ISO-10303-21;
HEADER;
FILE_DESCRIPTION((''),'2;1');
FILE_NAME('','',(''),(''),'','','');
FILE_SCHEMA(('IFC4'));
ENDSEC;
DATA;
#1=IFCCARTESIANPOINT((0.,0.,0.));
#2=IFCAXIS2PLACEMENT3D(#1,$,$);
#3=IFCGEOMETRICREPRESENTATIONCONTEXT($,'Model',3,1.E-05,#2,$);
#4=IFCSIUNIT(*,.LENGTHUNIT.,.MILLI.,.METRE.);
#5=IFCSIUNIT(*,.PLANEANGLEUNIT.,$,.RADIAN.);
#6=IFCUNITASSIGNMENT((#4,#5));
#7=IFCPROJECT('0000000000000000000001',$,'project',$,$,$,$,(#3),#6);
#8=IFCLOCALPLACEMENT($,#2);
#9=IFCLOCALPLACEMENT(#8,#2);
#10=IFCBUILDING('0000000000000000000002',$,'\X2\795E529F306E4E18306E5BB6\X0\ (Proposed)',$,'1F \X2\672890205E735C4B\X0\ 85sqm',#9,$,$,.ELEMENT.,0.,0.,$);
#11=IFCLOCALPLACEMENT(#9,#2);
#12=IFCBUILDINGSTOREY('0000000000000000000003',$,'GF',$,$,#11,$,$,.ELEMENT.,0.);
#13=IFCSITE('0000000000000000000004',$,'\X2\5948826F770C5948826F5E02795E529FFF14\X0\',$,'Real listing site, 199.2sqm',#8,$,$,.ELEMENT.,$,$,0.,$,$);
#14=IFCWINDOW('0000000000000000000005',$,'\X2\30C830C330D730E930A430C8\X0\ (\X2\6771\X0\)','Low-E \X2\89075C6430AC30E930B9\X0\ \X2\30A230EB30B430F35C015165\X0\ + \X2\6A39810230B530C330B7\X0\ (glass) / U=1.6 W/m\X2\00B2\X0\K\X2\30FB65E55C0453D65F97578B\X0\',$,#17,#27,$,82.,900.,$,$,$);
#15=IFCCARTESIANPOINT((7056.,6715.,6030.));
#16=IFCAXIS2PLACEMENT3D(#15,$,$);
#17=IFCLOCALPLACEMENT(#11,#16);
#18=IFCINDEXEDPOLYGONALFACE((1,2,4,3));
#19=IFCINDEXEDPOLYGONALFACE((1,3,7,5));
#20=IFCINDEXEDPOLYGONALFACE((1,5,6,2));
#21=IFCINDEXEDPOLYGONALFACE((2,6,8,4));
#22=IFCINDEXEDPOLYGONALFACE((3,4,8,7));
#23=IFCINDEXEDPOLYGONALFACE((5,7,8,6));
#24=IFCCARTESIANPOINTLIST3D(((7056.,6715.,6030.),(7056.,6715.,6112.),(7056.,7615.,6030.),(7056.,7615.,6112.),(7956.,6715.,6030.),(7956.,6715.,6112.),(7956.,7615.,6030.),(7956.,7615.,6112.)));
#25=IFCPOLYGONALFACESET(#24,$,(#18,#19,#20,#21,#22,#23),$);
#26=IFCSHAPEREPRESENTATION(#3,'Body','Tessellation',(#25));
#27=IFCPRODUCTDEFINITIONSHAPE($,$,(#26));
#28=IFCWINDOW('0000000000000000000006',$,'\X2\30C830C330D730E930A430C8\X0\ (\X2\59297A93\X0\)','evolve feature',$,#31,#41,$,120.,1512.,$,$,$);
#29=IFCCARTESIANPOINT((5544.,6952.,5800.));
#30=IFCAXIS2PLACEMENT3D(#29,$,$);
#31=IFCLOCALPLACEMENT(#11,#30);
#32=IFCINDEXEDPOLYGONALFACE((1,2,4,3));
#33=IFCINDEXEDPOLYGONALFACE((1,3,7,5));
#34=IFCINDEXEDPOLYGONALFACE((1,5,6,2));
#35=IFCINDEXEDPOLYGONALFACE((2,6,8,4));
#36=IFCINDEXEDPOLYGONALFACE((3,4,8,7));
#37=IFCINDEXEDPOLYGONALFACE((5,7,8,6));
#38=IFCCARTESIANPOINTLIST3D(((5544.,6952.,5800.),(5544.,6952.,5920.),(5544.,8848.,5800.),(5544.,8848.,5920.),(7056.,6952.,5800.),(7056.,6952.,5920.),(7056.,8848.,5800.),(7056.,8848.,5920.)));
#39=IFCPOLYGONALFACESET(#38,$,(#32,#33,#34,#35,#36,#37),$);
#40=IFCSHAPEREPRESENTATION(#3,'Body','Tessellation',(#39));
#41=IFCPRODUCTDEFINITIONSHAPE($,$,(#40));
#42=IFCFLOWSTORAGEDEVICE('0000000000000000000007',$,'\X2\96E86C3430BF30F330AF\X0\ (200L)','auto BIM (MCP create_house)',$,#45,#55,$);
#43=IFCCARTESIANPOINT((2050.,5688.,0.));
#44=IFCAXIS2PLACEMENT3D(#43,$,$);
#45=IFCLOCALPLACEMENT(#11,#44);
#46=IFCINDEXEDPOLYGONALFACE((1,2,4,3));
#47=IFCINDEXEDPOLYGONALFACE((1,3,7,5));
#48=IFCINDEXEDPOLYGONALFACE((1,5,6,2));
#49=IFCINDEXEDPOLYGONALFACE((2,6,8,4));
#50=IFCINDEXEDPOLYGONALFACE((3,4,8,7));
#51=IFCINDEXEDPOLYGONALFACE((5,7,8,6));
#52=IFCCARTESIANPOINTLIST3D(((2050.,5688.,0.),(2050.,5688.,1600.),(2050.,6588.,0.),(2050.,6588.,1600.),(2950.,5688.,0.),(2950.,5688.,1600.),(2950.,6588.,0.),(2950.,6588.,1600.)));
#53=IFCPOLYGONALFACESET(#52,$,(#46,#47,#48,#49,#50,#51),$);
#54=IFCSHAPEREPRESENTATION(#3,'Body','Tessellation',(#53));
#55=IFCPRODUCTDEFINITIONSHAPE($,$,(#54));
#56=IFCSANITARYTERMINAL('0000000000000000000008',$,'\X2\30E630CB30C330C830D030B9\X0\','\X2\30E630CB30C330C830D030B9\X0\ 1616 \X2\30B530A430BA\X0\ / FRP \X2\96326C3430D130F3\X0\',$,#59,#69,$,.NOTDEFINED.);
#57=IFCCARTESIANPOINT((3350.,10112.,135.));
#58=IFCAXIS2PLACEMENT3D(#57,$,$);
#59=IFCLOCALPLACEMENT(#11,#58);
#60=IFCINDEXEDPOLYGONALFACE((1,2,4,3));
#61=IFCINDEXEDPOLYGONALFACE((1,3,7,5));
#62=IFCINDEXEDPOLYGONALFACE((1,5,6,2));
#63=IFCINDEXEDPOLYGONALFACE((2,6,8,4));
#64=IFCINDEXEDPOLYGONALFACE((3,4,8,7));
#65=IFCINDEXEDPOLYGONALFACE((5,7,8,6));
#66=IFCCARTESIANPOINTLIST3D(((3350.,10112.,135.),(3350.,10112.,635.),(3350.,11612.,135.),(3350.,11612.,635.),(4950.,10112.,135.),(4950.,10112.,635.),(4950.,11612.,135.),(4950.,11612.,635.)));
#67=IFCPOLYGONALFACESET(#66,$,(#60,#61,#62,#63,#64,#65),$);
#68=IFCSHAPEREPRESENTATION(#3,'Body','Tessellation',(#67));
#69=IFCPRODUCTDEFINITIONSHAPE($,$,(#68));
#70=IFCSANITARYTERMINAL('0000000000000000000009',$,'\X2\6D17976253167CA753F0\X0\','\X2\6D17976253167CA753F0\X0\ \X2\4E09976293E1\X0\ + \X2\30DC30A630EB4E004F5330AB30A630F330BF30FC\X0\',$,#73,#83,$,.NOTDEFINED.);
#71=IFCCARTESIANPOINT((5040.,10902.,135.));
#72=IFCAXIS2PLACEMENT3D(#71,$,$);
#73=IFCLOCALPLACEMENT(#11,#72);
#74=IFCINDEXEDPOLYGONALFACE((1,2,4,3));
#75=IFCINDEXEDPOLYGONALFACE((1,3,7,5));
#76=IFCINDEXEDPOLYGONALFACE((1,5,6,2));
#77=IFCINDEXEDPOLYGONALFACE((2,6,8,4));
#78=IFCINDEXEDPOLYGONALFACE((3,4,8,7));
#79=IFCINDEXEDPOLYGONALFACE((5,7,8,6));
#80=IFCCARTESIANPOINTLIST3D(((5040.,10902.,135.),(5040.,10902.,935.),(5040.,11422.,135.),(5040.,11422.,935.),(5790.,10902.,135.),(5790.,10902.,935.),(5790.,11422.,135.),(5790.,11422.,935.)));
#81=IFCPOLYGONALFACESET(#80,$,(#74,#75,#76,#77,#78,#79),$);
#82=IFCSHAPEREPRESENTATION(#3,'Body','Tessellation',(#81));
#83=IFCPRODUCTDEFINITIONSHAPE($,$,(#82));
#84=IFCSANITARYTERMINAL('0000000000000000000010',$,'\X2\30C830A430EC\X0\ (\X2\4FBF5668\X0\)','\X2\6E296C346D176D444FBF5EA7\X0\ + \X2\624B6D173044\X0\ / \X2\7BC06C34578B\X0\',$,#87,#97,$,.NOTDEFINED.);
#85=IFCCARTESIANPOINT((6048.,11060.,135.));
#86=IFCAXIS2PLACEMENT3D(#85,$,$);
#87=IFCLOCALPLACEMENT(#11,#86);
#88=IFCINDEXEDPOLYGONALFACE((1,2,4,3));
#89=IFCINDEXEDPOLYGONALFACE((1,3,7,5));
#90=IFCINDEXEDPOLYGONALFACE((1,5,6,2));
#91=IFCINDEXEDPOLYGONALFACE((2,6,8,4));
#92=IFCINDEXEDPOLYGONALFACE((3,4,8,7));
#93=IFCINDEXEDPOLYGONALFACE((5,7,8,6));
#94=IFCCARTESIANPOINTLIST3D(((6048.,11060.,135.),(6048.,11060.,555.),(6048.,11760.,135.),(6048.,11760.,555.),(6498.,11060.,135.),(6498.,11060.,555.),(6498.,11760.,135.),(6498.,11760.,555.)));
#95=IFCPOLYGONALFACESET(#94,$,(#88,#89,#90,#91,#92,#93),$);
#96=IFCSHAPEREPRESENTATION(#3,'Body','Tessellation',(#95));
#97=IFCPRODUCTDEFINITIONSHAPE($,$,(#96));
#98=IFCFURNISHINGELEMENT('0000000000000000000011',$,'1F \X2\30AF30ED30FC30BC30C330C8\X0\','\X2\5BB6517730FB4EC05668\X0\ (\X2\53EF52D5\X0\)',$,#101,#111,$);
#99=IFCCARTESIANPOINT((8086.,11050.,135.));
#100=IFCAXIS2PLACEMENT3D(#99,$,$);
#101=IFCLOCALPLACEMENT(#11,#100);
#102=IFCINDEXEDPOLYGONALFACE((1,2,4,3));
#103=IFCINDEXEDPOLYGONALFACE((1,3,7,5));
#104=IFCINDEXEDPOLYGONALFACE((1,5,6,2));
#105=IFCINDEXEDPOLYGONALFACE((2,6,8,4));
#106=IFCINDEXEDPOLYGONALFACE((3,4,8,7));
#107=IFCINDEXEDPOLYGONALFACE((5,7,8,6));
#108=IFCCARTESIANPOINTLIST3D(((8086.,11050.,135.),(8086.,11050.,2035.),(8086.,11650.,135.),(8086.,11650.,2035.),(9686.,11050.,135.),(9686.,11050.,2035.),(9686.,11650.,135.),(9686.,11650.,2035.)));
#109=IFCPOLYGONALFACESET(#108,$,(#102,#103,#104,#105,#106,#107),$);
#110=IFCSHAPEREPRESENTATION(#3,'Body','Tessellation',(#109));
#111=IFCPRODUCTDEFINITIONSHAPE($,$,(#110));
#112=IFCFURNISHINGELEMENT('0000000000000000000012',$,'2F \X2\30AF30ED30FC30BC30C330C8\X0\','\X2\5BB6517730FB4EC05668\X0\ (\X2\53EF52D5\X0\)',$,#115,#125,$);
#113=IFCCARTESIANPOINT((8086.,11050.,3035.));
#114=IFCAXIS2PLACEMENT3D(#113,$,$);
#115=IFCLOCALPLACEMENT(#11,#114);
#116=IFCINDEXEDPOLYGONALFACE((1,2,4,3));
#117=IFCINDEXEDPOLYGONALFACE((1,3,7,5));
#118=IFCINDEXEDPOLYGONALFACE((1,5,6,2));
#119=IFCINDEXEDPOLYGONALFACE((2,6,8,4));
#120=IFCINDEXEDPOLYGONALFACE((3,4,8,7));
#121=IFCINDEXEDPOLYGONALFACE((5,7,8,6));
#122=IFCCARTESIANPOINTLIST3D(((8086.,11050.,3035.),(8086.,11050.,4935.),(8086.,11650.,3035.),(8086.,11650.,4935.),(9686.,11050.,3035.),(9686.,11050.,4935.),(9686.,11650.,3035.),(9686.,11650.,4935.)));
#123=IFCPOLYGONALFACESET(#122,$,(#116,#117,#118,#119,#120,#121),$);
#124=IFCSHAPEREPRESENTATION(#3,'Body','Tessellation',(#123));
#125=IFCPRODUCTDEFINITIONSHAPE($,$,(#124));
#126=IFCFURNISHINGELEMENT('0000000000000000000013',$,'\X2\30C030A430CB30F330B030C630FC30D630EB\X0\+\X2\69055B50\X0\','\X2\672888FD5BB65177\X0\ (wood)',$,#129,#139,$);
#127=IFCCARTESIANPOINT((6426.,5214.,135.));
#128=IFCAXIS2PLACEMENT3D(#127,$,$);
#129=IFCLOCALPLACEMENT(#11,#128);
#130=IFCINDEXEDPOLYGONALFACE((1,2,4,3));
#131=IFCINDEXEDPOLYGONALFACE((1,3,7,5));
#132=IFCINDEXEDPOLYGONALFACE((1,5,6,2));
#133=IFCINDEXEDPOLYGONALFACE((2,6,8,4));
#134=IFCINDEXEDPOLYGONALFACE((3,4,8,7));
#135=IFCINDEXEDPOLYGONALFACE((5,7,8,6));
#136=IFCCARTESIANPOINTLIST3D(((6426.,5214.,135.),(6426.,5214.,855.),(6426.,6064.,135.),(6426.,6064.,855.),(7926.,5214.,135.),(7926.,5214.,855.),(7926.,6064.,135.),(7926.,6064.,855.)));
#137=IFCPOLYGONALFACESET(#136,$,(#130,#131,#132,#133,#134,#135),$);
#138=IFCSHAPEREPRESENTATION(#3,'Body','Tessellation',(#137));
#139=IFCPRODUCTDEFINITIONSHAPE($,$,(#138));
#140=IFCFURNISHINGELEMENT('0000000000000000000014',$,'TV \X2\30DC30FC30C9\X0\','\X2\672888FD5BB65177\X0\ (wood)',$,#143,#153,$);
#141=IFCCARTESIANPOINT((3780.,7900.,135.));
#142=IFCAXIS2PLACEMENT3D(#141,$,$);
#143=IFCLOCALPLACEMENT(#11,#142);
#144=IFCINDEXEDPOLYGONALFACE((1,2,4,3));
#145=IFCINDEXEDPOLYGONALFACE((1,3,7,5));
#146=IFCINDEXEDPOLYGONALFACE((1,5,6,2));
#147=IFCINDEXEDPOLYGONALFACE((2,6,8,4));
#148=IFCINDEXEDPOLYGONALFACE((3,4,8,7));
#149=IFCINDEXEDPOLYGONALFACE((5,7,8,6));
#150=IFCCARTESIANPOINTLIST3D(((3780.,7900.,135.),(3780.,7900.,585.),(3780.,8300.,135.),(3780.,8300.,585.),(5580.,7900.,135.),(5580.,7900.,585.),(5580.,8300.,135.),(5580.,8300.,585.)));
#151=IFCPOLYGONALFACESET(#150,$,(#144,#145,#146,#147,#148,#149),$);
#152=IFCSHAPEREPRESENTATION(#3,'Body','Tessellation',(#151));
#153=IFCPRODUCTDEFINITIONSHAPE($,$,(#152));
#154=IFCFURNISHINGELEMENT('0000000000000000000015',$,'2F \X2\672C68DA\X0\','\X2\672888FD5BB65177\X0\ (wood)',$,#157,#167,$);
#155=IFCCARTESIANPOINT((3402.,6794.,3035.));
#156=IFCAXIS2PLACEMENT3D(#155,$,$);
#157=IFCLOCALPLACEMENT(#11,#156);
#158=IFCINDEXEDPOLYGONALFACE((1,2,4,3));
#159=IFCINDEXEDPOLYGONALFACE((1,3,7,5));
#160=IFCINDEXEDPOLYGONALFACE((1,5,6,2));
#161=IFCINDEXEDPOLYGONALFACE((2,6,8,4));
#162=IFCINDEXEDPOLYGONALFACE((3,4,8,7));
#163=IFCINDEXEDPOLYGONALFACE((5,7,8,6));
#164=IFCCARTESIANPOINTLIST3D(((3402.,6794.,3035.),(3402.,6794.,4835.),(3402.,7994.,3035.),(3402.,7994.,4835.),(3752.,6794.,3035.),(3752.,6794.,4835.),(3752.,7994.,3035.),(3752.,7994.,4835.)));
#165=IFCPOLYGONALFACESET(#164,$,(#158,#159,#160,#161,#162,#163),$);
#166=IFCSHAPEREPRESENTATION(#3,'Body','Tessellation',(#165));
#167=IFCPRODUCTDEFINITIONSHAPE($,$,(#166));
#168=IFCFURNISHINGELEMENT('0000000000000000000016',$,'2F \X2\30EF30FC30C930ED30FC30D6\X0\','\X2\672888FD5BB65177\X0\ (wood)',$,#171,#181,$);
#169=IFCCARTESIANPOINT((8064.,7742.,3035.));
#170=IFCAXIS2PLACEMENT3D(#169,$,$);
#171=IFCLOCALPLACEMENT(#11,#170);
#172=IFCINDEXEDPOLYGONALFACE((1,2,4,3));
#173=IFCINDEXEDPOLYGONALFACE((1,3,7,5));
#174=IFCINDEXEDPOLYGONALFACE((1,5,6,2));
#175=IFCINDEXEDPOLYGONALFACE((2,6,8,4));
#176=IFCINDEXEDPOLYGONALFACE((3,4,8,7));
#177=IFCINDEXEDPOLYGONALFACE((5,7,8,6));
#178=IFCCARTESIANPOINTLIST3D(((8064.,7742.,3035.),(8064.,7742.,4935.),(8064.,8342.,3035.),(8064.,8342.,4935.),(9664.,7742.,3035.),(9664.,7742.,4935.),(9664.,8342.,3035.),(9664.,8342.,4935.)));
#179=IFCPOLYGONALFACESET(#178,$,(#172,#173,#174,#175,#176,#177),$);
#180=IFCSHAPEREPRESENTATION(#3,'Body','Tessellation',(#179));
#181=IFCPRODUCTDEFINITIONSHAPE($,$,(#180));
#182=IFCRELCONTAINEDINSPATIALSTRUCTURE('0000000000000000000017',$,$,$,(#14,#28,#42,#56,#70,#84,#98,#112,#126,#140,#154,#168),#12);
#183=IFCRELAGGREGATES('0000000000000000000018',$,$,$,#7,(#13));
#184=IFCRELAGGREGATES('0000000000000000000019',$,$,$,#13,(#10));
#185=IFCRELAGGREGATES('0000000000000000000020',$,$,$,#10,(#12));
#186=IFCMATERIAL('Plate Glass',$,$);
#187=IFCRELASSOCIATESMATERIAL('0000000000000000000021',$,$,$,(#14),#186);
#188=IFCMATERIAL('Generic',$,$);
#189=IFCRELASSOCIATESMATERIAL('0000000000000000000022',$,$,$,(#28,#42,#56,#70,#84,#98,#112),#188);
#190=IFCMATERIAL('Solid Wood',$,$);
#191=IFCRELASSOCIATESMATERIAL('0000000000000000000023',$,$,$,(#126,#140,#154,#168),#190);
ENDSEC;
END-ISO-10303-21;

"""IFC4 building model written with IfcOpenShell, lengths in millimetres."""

from ifc_helpers import new_model, si_unit, frame, frame_2d, origin, place, context, project, spatial, rectangle, extrude, material, element, save


model = new_model("IFC4")

# Units and contexts
model_context = context("Model", 3, precision=1e-05, world=origin())
ifc_project = project(units=[si_unit("LENGTHUNIT", "METRE", prefix="MILLI"), si_unit("PLANEANGLEUNIT", "RADIAN")], contexts=[model_context])

# Site, building, storey
site_placement = place(None, origin())
site = spatial("IfcSite", under=ifc_project, at=site_placement, Name="奈良県奈良市神功４", ObjectType="Real listing site, 199.2sqm", CompositionType="ELEMENT", RefElevation=0.0)
building_placement = place(site_placement, origin())
building = spatial("IfcBuilding", under=site, at=building_placement, Name="神功の丘の家 (Proposed)", ObjectType="1F 木造平屋 85sqm", CompositionType="ELEMENT", ElevationOfRefHeight=0.0, ElevationOfTerrain=0.0)
storey_placement = place(building_placement, origin())
storey = spatial("IfcBuildingStorey", under=building, at=storey_placement, Name="GF", CompositionType="ELEMENT", Elevation=0.0)

# Shared definitions
ifc_material_1 = material(Name="Solid Wood")
ifc_material_2 = material(Name="Plate Glass")

# Windows
window_1_placement = place(storey_placement, frame((7056.0, 6715.0, 6030.0)))
element("IfcWindow", 1, at=window_1_placement, inside=storey, material=ifc_material_2, Name="トップライト (東)", Description="Low-E 複層ガラス アルゴン封入 + 樹脂サッシ (glass) / U=1.6 W/m²K・日射取得型", OverallHeight=82.0, OverallWidth=900.0, context=model_context, shape_type="SweptSolid", body=[
    extrude(rectangle(XDim=900.0, YDim=900.0, at=frame_2d((450.0, 450.0))), frame((7056.0, 6715.0, 6030.0)), (0.0, 0.0, 1.0), 82.0),
])
ifc_material_3 = material(Name="Generic")
window_2_placement = place(storey_placement, frame((5544.0, 6952.0, 5800.0)))
element("IfcWindow", 2, at=window_2_placement, inside=storey, material=ifc_material_3, Name="トップライト (天窓)", Description="evolve feature", OverallHeight=120.0, OverallWidth=1512.0, context=model_context, shape_type="SweptSolid", body=[
    extrude(rectangle(XDim=1512.0, YDim=1896.0, at=frame_2d((756.0, 948.0))), frame((5544.0, 6952.0, 5800.0)), (0.0, 0.0, 1.0), 120.0),
])

# Flow storage device
flow_storage_device_placement = place(storey_placement, frame((2050.0, 5688.0, 0.0)))
element("IfcFlowStorageDevice", 3, at=flow_storage_device_placement, inside=storey, material=ifc_material_3, Name="雨水タンク (200L)", Description="auto BIM (MCP create_house)", context=model_context, shape_type="SweptSolid", body=[
    extrude(rectangle(XDim=900.0, YDim=900.0, at=frame_2d((450.0, 450.0))), frame((2050.0, 5688.0, 0.0)), (0.0, 0.0, 1.0), 1600.0),
])

# Sanitary terminals
sanitary_terminal_1_placement = place(storey_placement, frame((3350.0, 10112.0, 135.0)))
element("IfcSanitaryTerminal", 4, at=sanitary_terminal_1_placement, inside=storey, material=ifc_material_3, Name="ユニットバス", Description="ユニットバス 1616 サイズ / FRP 防水パン", PredefinedType="NOTDEFINED", context=model_context, shape_type="SweptSolid", body=[
    extrude(rectangle(XDim=1600.0, YDim=1500.0, at=frame_2d((800.0, 750.0))), frame((3350.0, 10112.0, 135.0)), (0.0, 0.0, 1.0), 500.0),
])
sanitary_terminal_2_placement = place(storey_placement, frame((5040.0, 10902.0, 135.0)))
element("IfcSanitaryTerminal", 5, at=sanitary_terminal_2_placement, inside=storey, material=ifc_material_3, Name="洗面化粧台", Description="洗面化粧台 三面鏡 + ボウル一体カウンター", PredefinedType="NOTDEFINED", context=model_context, shape_type="SweptSolid", body=[
    extrude(rectangle(XDim=750.0, YDim=520.0, at=frame_2d((375.0, 260.0))), frame((5040.0, 10902.0, 135.0)), (0.0, 0.0, 1.0), 800.0),
])
sanitary_terminal_3_placement = place(storey_placement, frame((6048.0, 11060.0, 135.0)))
element("IfcSanitaryTerminal", 6, at=sanitary_terminal_3_placement, inside=storey, material=ifc_material_3, Name="トイレ (便器)", Description="温水洗浄便座 + 手洗い / 節水型", PredefinedType="NOTDEFINED", context=model_context, shape_type="SweptSolid", body=[
    extrude(rectangle(XDim=450.0, YDim=700.0, at=frame_2d((225.0, 350.0))), frame((6048.0, 11060.0, 135.0)), (0.0, 0.0, 1.0), 420.0),
])

# Furnishing elements
furnishing_1_placement = place(storey_placement, frame((8086.0, 11050.0, 135.0)))
element("IfcFurnishingElement", 7, at=furnishing_1_placement, inside=storey, material=ifc_material_3, Name="1F クローゼット", Description="家具・什器 (可動)", context=model_context, shape_type="SweptSolid", body=[
    extrude(rectangle(XDim=1600.0, YDim=600.0, at=frame_2d((800.0, 300.0))), frame((8086.0, 11050.0, 135.0)), (0.0, 0.0, 1.0), 1900.0),
])
furnishing_2_placement = place(storey_placement, frame((8086.0, 11050.0, 3035.0)))
element("IfcFurnishingElement", 8, at=furnishing_2_placement, inside=storey, material=ifc_material_3, Name="2F クローゼット", Description="家具・什器 (可動)", context=model_context, shape_type="SweptSolid", body=[
    extrude(rectangle(XDim=1600.0, YDim=600.0, at=frame_2d((800.0, 300.0))), frame((8086.0, 11050.0, 3035.0)), (0.0, 0.0, 1.0), 1900.0),
])
furnishing_3_placement = place(storey_placement, frame((6426.0, 5214.0, 135.0)))
element("IfcFurnishingElement", 9, at=furnishing_3_placement, inside=storey, material=ifc_material_1, Name="ダイニングテーブル+椅子", Description="木製家具 (wood)", context=model_context, shape_type="SweptSolid", body=[
    extrude(rectangle(XDim=1500.0, YDim=850.0, at=frame_2d((750.0, 425.0))), frame((6426.0, 5214.0, 135.0)), (0.0, 0.0, 1.0), 720.0),
])
furnishing_4_placement = place(storey_placement, frame((3780.0, 7900.0, 135.0)))
element("IfcFurnishingElement", 10, at=furnishing_4_placement, inside=storey, material=ifc_material_1, Name="TV ボード", Description="木製家具 (wood)", context=model_context, shape_type="SweptSolid", body=[
    extrude(rectangle(XDim=1800.0, YDim=400.0, at=frame_2d((900.0, 200.0))), frame((3780.0, 7900.0, 135.0)), (0.0, 0.0, 1.0), 450.0),
])
furnishing_5_placement = place(storey_placement, frame((3402.0, 6794.0, 3035.0)))
element("IfcFurnishingElement", 11, at=furnishing_5_placement, inside=storey, material=ifc_material_1, Name="2F 本棚", Description="木製家具 (wood)", context=model_context, shape_type="SweptSolid", body=[
    extrude(rectangle(XDim=350.0, YDim=1200.0, at=frame_2d((175.0, 600.0))), frame((3402.0, 6794.0, 3035.0)), (0.0, 0.0, 1.0), 1800.0),
])
furnishing_6_placement = place(storey_placement, frame((8064.0, 7742.0, 3035.0)))
element("IfcFurnishingElement", 12, at=furnishing_6_placement, inside=storey, material=ifc_material_1, Name="2F ワードローブ", Description="木製家具 (wood)", context=model_context, shape_type="SweptSolid", body=[
    extrude(rectangle(XDim=1600.0, YDim=600.0, at=frame_2d((800.0, 300.0))), frame((8064.0, 7742.0, 3035.0)), (0.0, 0.0, 1.0), 1900.0),
])

save(model, "model.ifc")
